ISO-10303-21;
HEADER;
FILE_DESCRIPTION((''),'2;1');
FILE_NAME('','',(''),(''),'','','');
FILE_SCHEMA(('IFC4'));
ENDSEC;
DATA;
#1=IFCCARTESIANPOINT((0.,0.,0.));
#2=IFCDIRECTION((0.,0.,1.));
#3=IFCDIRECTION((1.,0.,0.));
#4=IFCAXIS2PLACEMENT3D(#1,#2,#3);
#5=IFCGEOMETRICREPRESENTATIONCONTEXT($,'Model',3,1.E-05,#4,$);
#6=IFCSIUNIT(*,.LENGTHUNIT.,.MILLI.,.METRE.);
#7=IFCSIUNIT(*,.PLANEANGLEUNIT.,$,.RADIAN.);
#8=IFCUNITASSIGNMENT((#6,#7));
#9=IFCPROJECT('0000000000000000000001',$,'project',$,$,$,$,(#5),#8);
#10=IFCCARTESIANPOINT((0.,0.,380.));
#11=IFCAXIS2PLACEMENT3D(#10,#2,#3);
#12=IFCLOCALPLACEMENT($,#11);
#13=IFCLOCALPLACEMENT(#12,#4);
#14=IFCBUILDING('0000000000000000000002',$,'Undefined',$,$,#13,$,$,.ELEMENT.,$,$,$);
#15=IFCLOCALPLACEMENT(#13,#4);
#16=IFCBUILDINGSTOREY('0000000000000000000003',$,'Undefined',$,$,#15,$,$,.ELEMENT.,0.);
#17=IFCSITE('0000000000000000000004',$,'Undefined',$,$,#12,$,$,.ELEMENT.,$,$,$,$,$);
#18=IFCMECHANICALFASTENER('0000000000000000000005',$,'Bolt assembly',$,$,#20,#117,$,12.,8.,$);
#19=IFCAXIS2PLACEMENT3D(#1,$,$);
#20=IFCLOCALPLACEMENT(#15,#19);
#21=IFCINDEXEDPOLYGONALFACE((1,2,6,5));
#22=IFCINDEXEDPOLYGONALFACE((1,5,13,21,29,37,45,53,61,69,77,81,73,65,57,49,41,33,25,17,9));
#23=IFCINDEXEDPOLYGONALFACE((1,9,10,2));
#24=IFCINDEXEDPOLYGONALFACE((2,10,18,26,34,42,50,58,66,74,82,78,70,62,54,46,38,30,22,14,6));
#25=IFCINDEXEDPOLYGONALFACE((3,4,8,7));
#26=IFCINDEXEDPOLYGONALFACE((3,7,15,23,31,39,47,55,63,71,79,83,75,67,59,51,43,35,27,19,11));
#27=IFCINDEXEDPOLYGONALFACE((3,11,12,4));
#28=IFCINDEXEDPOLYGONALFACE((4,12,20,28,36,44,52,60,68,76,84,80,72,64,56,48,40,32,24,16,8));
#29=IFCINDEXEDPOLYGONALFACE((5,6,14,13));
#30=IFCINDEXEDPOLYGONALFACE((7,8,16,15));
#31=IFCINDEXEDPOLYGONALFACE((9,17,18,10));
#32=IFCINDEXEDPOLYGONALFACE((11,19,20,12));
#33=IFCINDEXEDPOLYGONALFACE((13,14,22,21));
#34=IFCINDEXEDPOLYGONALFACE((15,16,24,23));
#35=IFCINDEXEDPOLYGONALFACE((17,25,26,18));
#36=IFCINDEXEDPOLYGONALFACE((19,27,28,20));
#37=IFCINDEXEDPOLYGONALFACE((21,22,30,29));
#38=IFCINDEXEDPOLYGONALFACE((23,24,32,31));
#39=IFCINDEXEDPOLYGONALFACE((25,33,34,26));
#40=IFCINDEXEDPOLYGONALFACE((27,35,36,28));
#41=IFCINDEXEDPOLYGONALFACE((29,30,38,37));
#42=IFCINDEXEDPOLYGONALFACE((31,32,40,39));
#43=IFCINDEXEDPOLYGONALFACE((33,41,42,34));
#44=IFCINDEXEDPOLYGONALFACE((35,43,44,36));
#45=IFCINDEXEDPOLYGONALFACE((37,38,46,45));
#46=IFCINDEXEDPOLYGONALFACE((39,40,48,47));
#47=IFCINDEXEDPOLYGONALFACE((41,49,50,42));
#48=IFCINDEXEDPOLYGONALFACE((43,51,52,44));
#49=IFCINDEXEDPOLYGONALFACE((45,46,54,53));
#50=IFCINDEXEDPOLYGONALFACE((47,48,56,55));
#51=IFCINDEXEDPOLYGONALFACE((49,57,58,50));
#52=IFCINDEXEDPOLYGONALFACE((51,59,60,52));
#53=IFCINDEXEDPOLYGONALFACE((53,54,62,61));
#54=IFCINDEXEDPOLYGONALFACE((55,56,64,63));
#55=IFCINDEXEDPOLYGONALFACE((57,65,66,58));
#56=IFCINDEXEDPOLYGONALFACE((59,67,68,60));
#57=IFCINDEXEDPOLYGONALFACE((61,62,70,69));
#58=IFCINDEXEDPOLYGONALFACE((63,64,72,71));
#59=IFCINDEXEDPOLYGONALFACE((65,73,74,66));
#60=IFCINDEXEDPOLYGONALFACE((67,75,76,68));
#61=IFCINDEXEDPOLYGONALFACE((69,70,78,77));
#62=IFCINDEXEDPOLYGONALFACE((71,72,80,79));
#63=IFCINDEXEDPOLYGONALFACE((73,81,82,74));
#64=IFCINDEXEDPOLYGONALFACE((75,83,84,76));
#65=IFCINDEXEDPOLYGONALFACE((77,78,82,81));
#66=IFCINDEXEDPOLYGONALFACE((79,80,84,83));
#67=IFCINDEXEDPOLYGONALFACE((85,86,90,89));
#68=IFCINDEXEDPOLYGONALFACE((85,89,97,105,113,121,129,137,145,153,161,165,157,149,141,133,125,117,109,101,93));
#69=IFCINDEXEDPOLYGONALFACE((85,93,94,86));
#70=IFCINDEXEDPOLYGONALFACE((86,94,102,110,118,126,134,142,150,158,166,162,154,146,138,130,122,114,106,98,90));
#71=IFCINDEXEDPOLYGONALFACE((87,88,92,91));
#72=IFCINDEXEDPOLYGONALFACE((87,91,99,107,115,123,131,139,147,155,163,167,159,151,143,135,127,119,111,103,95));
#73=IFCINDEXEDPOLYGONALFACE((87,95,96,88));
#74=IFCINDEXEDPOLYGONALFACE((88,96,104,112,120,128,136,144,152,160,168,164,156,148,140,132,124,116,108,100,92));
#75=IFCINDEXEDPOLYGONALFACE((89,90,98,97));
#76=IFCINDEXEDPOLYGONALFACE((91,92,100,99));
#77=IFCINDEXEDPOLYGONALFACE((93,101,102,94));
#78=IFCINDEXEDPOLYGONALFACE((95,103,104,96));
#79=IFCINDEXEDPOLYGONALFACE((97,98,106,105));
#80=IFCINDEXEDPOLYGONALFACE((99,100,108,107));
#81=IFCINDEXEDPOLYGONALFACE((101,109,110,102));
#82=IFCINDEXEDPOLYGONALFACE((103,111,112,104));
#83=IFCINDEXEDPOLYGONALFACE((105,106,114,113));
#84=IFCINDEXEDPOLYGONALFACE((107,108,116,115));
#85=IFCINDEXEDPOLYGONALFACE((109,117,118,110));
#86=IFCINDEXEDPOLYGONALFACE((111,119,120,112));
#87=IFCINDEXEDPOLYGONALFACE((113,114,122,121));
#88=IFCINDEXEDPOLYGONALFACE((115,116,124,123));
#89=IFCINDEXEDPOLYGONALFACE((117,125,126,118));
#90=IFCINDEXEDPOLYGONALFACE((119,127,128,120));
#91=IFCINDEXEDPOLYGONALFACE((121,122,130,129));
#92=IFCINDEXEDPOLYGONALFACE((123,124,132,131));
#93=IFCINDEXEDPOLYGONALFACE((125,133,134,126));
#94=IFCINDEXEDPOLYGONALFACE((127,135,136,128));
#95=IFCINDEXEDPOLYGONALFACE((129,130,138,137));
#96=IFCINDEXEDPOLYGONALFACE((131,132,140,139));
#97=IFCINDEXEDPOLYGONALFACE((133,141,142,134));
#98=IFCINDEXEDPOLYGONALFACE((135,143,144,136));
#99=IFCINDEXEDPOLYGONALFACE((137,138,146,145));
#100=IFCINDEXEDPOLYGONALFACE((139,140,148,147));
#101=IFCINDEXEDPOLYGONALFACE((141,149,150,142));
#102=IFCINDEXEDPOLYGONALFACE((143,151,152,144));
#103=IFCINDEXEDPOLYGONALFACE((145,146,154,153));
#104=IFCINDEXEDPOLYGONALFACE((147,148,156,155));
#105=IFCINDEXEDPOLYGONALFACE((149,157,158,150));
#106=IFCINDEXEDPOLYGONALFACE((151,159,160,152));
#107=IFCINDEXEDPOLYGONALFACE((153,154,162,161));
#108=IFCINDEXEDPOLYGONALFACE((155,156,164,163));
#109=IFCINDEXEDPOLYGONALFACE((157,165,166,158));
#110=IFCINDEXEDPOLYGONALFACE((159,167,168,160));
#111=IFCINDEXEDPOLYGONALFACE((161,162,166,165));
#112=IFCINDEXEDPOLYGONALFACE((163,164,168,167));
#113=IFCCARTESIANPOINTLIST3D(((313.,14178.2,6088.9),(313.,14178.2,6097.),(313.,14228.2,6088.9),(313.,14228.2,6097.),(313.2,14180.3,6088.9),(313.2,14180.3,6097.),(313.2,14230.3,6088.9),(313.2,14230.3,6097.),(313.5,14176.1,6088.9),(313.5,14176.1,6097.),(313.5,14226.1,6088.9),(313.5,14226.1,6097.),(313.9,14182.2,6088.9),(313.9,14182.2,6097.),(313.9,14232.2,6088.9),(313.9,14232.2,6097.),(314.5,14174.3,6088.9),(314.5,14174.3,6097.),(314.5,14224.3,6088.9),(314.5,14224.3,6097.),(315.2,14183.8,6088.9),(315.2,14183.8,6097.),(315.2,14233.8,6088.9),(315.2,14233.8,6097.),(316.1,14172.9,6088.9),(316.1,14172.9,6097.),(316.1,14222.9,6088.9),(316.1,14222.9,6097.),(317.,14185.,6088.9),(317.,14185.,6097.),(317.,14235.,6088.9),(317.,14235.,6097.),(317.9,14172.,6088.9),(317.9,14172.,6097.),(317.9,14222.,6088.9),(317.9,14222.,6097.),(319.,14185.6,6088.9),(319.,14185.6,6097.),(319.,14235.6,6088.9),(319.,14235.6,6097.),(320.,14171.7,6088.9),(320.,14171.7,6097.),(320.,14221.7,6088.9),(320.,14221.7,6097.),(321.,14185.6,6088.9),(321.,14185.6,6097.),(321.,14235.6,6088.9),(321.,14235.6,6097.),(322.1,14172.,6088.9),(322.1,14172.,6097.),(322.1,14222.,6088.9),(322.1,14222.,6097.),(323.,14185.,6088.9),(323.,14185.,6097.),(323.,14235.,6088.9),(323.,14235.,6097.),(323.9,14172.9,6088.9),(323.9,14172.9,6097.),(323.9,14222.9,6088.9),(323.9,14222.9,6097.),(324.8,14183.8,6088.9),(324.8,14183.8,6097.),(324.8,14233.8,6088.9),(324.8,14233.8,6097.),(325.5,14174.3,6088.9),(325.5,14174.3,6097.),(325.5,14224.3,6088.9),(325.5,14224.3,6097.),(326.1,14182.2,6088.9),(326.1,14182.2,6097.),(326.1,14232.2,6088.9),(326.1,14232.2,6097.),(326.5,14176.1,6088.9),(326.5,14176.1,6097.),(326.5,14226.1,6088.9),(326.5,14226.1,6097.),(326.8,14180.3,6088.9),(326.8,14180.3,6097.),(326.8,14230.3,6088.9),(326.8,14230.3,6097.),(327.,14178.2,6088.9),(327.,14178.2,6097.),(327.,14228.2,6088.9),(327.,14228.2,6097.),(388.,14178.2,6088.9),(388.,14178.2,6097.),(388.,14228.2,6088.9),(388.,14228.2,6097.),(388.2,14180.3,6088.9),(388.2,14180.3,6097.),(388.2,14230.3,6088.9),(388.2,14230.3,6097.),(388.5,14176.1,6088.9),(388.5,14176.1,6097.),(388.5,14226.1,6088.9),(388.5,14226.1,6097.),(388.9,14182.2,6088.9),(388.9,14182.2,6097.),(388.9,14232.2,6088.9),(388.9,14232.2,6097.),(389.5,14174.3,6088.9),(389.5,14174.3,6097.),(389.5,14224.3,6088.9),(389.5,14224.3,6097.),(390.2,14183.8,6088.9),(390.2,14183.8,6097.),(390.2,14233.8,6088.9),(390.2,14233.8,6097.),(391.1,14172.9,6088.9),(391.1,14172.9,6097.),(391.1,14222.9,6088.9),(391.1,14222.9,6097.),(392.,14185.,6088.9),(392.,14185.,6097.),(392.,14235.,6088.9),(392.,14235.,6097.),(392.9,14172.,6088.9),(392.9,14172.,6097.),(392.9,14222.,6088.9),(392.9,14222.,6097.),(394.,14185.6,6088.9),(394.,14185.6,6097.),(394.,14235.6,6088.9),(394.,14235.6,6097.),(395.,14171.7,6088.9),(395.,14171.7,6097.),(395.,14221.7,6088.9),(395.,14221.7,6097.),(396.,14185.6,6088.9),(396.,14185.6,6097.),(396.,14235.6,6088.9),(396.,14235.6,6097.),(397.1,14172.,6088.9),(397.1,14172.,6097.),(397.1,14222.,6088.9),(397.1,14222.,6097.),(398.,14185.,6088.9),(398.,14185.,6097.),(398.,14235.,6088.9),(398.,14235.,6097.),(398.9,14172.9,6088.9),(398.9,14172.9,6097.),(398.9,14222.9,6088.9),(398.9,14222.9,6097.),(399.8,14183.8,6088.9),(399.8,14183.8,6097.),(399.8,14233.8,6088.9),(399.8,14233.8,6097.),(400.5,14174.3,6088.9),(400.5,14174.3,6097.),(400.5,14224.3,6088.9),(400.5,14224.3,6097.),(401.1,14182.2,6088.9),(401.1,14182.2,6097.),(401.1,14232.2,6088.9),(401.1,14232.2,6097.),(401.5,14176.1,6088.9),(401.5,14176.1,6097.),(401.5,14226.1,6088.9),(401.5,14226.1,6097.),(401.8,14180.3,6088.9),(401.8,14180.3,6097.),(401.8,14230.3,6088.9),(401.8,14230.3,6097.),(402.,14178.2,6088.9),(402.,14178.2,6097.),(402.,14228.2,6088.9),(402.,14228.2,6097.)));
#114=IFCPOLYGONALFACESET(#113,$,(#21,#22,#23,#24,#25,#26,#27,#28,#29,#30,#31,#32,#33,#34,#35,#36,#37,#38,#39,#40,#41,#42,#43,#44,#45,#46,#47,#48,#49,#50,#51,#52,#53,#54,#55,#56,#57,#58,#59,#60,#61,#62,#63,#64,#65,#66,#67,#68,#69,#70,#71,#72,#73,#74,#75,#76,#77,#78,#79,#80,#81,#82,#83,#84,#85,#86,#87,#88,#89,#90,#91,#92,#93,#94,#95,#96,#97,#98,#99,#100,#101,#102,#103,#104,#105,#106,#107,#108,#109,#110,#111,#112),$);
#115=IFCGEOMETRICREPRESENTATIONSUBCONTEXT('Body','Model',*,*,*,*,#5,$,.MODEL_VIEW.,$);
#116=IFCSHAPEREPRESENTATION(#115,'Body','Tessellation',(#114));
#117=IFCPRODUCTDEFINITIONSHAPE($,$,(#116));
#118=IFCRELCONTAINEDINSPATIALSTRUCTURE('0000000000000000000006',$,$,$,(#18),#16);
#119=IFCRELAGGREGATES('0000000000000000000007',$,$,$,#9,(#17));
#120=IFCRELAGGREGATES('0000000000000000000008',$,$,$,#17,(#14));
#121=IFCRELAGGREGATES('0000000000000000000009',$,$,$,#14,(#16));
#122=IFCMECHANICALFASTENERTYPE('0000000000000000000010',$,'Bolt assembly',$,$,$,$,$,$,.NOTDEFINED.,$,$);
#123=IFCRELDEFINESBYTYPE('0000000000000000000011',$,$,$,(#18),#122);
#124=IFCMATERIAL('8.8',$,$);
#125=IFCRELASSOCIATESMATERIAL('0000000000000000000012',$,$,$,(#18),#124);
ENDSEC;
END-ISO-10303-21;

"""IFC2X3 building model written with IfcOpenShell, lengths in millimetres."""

from ifc_helpers import new_model, si_unit, frame, origin_with_axes, origin_2d_with_axis, place, context, subcontext, project, spatial, circle, extrude, source, transform, mapped, material, type_object, element, save


model = new_model("IFC2X3")

# Units and contexts
model_context = context("Model", 3, precision=1e-05, world=origin_with_axes())
body_context = subcontext(model_context, "Body", "Model", "MODEL_VIEW")
ifc_project = project(units=[si_unit("LENGTHUNIT", "METRE", prefix="MILLI"), si_unit("PLANEANGLEUNIT", "RADIAN")], contexts=[model_context])

# Site, building, storey
site_placement = place(None, frame((0.0, 0.0, 380.0), z_axis=(0.0, 0.0, 1.0), x_axis=(1.0, 0.0, 0.0)))
site = spatial("IfcSite", under=ifc_project, at=site_placement, Name="Undefined", CompositionType="ELEMENT")
building_placement = place(site_placement, origin_with_axes())
building = spatial("IfcBuilding", under=site, at=building_placement, Name="Undefined", CompositionType="ELEMENT")
storey_placement = place(building_placement, origin_with_axes())
storey = spatial("IfcBuildingStorey", under=building, at=storey_placement, Name="Undefined", CompositionType="ELEMENT", Elevation=0.0)

# Mechanical fastener
ifc_material_1 = material(Name="8.8")
mechanical_fastener_type = type_object("IfcMechanicalFastenerType", Name="Bolt assembly")
shared_shape = source(origin_with_axes(), body_context, "Body", "SweptSolid", [
    extrude(circle(Radius=7.0, at=origin_2d_with_axis()), frame((0.0, 0.0, 0.0), z_axis=(0.0, 1.0, 0.0), x_axis=(1.0, 0.0, 0.0)), (0.0, 0.0, 1.0), 8.1),
])
mechanical_fastener_1_placement = place(storey_placement, frame((357.5, 14228.7, 6097.0), z_axis=(1.0, 0.0, 0.0), x_axis=(0.0, -1.0, 0.0)))
element("IfcMechanicalFastener", 1, at=mechanical_fastener_1_placement, inside=storey, type_object=mechanical_fastener_type, material=ifc_material_1, Name="Bolt assembly", NominalDiameter=12.0, NominalLength=8.0, context=body_context, shape_type="MappedRepresentation", body=[
    mapped(shared_shape, transform((0.0, 0.0, 37.5))),
    mapped(shared_shape, transform((50.0, 0.0, 37.5))),
    mapped(shared_shape, transform((0.0, 0.0, -37.5))),
    mapped(shared_shape, transform((50.0, 0.0, -37.5))),
])

save(model, "model.ifc")
